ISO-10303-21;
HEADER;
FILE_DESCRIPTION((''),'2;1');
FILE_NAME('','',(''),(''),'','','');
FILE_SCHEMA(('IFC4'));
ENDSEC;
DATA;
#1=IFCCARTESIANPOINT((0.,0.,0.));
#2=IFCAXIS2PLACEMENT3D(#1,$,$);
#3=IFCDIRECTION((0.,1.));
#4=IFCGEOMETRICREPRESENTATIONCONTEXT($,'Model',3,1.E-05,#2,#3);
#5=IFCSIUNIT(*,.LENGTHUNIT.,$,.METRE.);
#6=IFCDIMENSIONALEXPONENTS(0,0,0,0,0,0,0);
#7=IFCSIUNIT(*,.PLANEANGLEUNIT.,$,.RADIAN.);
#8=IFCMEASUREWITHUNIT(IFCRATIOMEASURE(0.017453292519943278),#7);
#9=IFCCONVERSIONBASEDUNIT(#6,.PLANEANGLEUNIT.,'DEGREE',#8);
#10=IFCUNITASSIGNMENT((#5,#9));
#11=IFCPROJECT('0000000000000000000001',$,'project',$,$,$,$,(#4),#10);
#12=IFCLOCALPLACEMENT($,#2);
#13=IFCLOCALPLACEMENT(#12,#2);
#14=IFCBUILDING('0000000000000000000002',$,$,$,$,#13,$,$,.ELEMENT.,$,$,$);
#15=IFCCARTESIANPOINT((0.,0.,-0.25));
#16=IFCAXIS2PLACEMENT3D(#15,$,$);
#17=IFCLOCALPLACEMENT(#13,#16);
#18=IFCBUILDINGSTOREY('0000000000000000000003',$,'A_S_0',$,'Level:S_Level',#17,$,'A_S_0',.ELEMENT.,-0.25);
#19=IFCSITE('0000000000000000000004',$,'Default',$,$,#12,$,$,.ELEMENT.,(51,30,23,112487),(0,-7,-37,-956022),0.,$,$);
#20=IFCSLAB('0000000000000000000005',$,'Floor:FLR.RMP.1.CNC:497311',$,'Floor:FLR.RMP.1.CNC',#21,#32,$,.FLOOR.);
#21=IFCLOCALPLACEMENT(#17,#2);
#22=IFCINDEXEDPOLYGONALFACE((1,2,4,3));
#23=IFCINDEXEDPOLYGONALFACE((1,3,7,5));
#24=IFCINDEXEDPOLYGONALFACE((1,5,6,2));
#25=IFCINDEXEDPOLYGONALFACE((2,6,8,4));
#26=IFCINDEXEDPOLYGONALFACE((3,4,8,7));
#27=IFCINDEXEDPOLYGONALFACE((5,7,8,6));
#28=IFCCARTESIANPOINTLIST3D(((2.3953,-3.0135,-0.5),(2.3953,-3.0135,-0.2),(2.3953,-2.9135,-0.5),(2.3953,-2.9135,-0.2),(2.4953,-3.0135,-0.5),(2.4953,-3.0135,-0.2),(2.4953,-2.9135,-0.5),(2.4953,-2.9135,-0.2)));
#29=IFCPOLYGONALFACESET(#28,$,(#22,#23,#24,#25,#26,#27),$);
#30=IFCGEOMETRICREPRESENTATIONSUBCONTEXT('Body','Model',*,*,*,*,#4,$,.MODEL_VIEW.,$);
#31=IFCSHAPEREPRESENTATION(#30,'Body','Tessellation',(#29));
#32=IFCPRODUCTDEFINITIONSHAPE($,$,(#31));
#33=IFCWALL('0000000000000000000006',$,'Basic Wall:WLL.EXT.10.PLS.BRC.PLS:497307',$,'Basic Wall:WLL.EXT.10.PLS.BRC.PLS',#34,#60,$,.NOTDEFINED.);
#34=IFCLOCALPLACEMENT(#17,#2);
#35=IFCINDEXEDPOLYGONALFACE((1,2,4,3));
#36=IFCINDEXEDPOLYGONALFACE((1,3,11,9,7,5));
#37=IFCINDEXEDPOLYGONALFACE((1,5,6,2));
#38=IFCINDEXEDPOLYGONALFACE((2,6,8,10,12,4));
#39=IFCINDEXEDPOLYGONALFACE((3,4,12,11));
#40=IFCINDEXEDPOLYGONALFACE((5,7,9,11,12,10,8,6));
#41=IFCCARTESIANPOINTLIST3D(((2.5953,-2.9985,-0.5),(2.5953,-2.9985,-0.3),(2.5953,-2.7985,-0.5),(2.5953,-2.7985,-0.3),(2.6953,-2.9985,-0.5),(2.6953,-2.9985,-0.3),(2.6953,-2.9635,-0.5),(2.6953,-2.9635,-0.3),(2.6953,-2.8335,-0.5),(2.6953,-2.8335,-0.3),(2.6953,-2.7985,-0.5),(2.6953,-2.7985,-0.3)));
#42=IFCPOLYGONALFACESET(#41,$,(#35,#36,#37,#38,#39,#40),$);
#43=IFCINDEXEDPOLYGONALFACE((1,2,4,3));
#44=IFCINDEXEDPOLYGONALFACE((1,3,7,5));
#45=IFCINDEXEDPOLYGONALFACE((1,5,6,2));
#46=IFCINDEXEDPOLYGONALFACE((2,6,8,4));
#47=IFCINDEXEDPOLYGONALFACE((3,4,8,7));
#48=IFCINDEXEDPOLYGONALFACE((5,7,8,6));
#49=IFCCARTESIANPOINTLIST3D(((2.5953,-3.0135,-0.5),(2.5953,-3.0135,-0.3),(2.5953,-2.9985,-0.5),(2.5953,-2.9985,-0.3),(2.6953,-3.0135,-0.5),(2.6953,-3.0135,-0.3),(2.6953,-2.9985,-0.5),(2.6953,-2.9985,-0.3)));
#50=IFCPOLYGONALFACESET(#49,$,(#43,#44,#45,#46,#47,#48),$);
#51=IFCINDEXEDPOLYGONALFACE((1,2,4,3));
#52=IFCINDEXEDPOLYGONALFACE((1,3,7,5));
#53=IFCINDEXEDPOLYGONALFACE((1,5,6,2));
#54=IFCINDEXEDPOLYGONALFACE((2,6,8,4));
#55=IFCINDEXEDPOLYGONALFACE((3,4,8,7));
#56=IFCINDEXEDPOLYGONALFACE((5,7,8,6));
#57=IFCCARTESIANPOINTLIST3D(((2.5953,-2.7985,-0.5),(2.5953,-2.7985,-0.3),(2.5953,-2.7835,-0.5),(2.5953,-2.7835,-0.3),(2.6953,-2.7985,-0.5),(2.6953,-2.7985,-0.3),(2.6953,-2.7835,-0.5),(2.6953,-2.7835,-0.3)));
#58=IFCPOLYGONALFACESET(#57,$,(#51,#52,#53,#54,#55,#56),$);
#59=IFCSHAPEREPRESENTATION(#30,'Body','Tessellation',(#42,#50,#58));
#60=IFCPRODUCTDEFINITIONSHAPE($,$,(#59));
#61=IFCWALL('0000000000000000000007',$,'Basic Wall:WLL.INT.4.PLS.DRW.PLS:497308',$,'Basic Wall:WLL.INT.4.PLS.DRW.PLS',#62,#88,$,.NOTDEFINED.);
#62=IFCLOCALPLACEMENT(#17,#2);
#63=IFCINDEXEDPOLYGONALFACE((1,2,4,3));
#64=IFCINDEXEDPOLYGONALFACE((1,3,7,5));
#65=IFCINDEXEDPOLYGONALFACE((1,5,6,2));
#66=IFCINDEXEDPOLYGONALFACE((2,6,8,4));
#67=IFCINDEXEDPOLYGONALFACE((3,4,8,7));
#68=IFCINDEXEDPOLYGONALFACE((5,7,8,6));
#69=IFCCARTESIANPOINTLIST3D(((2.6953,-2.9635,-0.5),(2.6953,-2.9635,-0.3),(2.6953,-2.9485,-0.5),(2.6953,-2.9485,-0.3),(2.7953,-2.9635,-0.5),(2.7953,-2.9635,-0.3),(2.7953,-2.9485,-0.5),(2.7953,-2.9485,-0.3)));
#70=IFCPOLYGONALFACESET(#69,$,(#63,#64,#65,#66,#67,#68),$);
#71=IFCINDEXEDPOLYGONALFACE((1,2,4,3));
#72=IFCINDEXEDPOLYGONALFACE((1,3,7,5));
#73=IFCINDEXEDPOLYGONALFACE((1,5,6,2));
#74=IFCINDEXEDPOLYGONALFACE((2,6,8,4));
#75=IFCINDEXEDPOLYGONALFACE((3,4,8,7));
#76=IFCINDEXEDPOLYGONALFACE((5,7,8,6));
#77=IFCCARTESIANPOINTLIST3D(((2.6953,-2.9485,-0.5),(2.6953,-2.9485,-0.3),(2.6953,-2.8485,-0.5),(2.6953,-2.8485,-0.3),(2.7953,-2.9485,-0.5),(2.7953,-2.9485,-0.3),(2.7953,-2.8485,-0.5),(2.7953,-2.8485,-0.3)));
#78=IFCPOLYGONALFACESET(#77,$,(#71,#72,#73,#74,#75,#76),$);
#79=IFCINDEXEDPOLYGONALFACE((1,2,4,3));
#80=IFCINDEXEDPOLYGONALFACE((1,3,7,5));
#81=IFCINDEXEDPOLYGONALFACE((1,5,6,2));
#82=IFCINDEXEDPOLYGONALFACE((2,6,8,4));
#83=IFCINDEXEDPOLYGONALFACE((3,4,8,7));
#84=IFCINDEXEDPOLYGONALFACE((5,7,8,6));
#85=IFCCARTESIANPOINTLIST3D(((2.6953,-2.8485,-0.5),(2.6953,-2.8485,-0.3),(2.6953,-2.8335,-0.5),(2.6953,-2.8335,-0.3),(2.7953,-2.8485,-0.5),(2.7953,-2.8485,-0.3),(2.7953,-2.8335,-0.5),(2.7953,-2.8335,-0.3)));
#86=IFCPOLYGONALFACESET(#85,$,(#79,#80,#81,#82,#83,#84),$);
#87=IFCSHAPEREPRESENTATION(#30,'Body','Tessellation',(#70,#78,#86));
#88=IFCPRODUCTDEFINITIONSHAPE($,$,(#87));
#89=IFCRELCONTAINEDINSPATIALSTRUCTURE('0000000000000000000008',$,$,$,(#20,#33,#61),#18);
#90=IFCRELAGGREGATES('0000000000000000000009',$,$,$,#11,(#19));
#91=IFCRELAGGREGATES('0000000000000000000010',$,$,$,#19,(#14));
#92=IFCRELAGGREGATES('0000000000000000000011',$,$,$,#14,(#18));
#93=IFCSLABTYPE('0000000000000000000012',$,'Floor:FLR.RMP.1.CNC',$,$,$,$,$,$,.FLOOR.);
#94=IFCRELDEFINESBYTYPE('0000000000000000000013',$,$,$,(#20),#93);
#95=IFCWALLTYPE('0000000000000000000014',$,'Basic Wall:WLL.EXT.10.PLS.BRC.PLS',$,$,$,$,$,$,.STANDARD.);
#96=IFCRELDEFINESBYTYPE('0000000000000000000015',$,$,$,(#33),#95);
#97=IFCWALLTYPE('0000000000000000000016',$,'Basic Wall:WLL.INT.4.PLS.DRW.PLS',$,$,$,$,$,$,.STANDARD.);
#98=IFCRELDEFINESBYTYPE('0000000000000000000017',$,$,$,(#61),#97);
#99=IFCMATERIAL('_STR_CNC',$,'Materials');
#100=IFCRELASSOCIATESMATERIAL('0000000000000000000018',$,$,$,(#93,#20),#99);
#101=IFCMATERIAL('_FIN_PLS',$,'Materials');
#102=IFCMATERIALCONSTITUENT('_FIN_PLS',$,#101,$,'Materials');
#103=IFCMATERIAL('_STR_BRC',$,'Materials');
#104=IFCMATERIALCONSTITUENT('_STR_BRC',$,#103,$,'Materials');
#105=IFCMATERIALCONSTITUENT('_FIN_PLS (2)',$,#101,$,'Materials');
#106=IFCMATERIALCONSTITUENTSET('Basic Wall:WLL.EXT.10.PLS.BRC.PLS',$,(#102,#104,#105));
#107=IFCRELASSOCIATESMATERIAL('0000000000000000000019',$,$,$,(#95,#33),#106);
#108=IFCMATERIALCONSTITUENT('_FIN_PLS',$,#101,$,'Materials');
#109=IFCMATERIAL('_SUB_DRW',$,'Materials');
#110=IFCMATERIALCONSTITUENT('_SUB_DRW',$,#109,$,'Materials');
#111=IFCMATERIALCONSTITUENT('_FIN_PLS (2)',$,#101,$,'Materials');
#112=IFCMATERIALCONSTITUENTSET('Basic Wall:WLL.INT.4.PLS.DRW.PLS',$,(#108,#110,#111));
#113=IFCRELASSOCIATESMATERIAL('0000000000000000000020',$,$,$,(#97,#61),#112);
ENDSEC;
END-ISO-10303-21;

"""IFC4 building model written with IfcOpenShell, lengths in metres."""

from ifc_helpers import new_model, entity, si_unit, converted_unit, direction, frame, origin, place, context, subcontext, project, spatial, indexed_curve, outline, extrude, material, constituent, constituent_set, type_object, element, save


model = new_model("IFC4")

# Units and contexts
model_context = context("Model", 3, precision=1e-05, world=origin(), true_north=direction((0.0, 1.0)))
body_context = subcontext(model_context, "Body", "Model", "MODEL_VIEW")
ifc_project = project(units=[si_unit("LENGTHUNIT", "METRE"), converted_unit("PLANEANGLEUNIT", "DEGREE", entity("IfcRatioMeasure", 0.017453292519943278), si_unit("PLANEANGLEUNIT", "RADIAN"), dimensions=[0, 0, 0, 0, 0, 0, 0])], contexts=[model_context])

# Site, building, storey
site_placement = place(None, origin())
site = spatial("IfcSite", under=ifc_project, at=site_placement, Name="Default", CompositionType="ELEMENT", RefLatitude=(51, 30, 23, 112487), RefLongitude=(0, -7, -37, -956022), RefElevation=0.0)
building_placement = place(site_placement, origin())
building = spatial("IfcBuilding", under=site, at=building_placement, CompositionType="ELEMENT")
storey_placement = place(building_placement, frame((0.0, 0.0, -0.25)))
storey = spatial("IfcBuildingStorey", under=building, at=storey_placement, Name="A_S_0", ObjectType="Level:S_Level", LongName="A_S_0", CompositionType="ELEMENT", Elevation=-0.25)

# Shared definitions
ifc_material_1 = material(Name="_STR_CNC", Category="Materials")

# Slab
slab_type = type_object("IfcSlabType", Name="Floor:FLR.RMP.1.CNC", PredefinedType="FLOOR", material=ifc_material_1)
slab_placement = place(storey_placement, origin())
element("IfcSlab", 1, at=slab_placement, inside=storey, type_object=slab_type, material=ifc_material_1, Name="Floor:FLR.RMP.1.CNC:497311", ObjectType="Floor:FLR.RMP.1.CNC", PredefinedType="FLOOR", context=body_context, shape_type="SweptSolid", body=[
    extrude(outline(indexed_curve([(-0.05, -0.05), (0.05, -0.05), (0.05, 0.05), (-0.05, 0.05), (-0.05, -0.05)], self_intersect=False)), frame((2.4453, -2.9635, -0.2), z_axis=(0.0, 0.0, -1.0), x_axis=(0.0, 1.0, 0.0)), (0.0, 0.0, 1.0), 0.3),
])

# Walls
ifc_material_2 = material(Name="_FIN_PLS", Category="Materials")
ifc_constituent_1 = constituent(ifc_material_2, Name="_FIN_PLS", Category="Materials")
ifc_material_3 = material(Name="_STR_BRC", Category="Materials")
ifc_constituent_2 = constituent(ifc_material_3, Name="_STR_BRC", Category="Materials")
ifc_constituent_3 = constituent(ifc_material_2, Name="_FIN_PLS (2)", Category="Materials")
ifc_constituent_set_1 = constituent_set(constituents=[ifc_constituent_1, ifc_constituent_2, ifc_constituent_3], Name="Basic Wall:WLL.EXT.10.PLS.BRC.PLS")
wall_type_1 = type_object("IfcWallType", Name="Basic Wall:WLL.EXT.10.PLS.BRC.PLS", PredefinedType="STANDARD", material=ifc_constituent_set_1)
wall_1_placement = place(storey_placement, frame((2.5953, -2.8985, -0.5)))
element("IfcWall", 2, at=wall_1_placement, inside=storey, type_object=wall_type_1, material=ifc_constituent_set_1, Name="Basic Wall:WLL.EXT.10.PLS.BRC.PLS:497307", ObjectType="Basic Wall:WLL.EXT.10.PLS.BRC.PLS", PredefinedType="NOTDEFINED", context=body_context, shape_type="SweptSolid", body=[
    extrude(outline(indexed_curve([(0.065, -0.0333), (0.1, -0.0333), (0.1, 0.0667), (-0.1, 0.0667), (-0.1, -0.0333), (-0.065, -0.0333), (0.065, -0.0333)], self_intersect=False)), frame((0.0667, 0.0, 0.0), z_axis=(0.0, 0.0, 1.0), x_axis=(0.0, 1.0, 0.0)), (0.0, 0.0, 1.0), 0.2),
    extrude(outline(indexed_curve([(-0.0075, -0.05), (0.0075, -0.05), (0.0075, 0.05), (-0.0075, 0.05), (-0.0075, -0.05)], self_intersect=False)), frame((0.05, -0.1075, 0.0), z_axis=(0.0, 0.0, 1.0), x_axis=(0.0, 1.0, 0.0)), (0.0, 0.0, 1.0), 0.2),
    extrude(outline(indexed_curve([(-0.0075, -0.05), (0.0075, -0.05), (0.0075, 0.05), (-0.0075, 0.05), (-0.0075, -0.05)], self_intersect=False)), frame((0.05, 0.1075, 0.0), z_axis=(0.0, 0.0, 1.0), x_axis=(0.0, -1.0, 0.0)), (0.0, 0.0, 1.0), 0.2),
])
ifc_constituent_4 = constituent(ifc_material_2, Name="_FIN_PLS", Category="Materials")
ifc_material_4 = material(Name="_SUB_DRW", Category="Materials")
ifc_constituent_5 = constituent(ifc_material_4, Name="_SUB_DRW", Category="Materials")
ifc_constituent_6 = constituent(ifc_material_2, Name="_FIN_PLS (2)", Category="Materials")
ifc_constituent_set_2 = constituent_set(constituents=[ifc_constituent_4, ifc_constituent_5, ifc_constituent_6], Name="Basic Wall:WLL.INT.4.PLS.DRW.PLS")
wall_type_2 = type_object("IfcWallType", Name="Basic Wall:WLL.INT.4.PLS.DRW.PLS", PredefinedType="STANDARD", material=ifc_constituent_set_2)
wall_2_placement = place(storey_placement, frame((2.6953, -2.8985, -0.5)))
element("IfcWall", 3, at=wall_2_placement, inside=storey, type_object=wall_type_2, material=ifc_constituent_set_2, Name="Basic Wall:WLL.INT.4.PLS.DRW.PLS:497308", ObjectType="Basic Wall:WLL.INT.4.PLS.DRW.PLS", PredefinedType="NOTDEFINED", context=body_context, shape_type="SweptSolid", body=[
    extrude(outline(indexed_curve([(-0.0075, -0.05), (0.0075, -0.05), (0.0075, 0.05), (-0.0075, 0.05), (-0.0075, -0.05)], self_intersect=False)), frame((0.05, -0.0575, 0.0), z_axis=(0.0, 0.0, 1.0), x_axis=(0.0, 1.0, 0.0)), (0.0, 0.0, 1.0), 0.2),
    extrude(outline(indexed_curve([(-0.05, -0.05), (0.05, -0.05), (0.05, 0.05), (-0.05, 0.05), (-0.05, -0.05)], self_intersect=False)), frame((0.05, 0.0, 0.0)), (0.0, 0.0, 1.0), 0.2),
    extrude(outline(indexed_curve([(-0.0075, -0.05), (0.0075, -0.05), (0.0075, 0.05), (-0.0075, 0.05), (-0.0075, -0.05)], self_intersect=False)), frame((0.05, 0.0575, 0.0), z_axis=(0.0, 0.0, 1.0), x_axis=(0.0, -1.0, 0.0)), (0.0, 0.0, 1.0), 0.2),
])

save(model, "model.ifc")
